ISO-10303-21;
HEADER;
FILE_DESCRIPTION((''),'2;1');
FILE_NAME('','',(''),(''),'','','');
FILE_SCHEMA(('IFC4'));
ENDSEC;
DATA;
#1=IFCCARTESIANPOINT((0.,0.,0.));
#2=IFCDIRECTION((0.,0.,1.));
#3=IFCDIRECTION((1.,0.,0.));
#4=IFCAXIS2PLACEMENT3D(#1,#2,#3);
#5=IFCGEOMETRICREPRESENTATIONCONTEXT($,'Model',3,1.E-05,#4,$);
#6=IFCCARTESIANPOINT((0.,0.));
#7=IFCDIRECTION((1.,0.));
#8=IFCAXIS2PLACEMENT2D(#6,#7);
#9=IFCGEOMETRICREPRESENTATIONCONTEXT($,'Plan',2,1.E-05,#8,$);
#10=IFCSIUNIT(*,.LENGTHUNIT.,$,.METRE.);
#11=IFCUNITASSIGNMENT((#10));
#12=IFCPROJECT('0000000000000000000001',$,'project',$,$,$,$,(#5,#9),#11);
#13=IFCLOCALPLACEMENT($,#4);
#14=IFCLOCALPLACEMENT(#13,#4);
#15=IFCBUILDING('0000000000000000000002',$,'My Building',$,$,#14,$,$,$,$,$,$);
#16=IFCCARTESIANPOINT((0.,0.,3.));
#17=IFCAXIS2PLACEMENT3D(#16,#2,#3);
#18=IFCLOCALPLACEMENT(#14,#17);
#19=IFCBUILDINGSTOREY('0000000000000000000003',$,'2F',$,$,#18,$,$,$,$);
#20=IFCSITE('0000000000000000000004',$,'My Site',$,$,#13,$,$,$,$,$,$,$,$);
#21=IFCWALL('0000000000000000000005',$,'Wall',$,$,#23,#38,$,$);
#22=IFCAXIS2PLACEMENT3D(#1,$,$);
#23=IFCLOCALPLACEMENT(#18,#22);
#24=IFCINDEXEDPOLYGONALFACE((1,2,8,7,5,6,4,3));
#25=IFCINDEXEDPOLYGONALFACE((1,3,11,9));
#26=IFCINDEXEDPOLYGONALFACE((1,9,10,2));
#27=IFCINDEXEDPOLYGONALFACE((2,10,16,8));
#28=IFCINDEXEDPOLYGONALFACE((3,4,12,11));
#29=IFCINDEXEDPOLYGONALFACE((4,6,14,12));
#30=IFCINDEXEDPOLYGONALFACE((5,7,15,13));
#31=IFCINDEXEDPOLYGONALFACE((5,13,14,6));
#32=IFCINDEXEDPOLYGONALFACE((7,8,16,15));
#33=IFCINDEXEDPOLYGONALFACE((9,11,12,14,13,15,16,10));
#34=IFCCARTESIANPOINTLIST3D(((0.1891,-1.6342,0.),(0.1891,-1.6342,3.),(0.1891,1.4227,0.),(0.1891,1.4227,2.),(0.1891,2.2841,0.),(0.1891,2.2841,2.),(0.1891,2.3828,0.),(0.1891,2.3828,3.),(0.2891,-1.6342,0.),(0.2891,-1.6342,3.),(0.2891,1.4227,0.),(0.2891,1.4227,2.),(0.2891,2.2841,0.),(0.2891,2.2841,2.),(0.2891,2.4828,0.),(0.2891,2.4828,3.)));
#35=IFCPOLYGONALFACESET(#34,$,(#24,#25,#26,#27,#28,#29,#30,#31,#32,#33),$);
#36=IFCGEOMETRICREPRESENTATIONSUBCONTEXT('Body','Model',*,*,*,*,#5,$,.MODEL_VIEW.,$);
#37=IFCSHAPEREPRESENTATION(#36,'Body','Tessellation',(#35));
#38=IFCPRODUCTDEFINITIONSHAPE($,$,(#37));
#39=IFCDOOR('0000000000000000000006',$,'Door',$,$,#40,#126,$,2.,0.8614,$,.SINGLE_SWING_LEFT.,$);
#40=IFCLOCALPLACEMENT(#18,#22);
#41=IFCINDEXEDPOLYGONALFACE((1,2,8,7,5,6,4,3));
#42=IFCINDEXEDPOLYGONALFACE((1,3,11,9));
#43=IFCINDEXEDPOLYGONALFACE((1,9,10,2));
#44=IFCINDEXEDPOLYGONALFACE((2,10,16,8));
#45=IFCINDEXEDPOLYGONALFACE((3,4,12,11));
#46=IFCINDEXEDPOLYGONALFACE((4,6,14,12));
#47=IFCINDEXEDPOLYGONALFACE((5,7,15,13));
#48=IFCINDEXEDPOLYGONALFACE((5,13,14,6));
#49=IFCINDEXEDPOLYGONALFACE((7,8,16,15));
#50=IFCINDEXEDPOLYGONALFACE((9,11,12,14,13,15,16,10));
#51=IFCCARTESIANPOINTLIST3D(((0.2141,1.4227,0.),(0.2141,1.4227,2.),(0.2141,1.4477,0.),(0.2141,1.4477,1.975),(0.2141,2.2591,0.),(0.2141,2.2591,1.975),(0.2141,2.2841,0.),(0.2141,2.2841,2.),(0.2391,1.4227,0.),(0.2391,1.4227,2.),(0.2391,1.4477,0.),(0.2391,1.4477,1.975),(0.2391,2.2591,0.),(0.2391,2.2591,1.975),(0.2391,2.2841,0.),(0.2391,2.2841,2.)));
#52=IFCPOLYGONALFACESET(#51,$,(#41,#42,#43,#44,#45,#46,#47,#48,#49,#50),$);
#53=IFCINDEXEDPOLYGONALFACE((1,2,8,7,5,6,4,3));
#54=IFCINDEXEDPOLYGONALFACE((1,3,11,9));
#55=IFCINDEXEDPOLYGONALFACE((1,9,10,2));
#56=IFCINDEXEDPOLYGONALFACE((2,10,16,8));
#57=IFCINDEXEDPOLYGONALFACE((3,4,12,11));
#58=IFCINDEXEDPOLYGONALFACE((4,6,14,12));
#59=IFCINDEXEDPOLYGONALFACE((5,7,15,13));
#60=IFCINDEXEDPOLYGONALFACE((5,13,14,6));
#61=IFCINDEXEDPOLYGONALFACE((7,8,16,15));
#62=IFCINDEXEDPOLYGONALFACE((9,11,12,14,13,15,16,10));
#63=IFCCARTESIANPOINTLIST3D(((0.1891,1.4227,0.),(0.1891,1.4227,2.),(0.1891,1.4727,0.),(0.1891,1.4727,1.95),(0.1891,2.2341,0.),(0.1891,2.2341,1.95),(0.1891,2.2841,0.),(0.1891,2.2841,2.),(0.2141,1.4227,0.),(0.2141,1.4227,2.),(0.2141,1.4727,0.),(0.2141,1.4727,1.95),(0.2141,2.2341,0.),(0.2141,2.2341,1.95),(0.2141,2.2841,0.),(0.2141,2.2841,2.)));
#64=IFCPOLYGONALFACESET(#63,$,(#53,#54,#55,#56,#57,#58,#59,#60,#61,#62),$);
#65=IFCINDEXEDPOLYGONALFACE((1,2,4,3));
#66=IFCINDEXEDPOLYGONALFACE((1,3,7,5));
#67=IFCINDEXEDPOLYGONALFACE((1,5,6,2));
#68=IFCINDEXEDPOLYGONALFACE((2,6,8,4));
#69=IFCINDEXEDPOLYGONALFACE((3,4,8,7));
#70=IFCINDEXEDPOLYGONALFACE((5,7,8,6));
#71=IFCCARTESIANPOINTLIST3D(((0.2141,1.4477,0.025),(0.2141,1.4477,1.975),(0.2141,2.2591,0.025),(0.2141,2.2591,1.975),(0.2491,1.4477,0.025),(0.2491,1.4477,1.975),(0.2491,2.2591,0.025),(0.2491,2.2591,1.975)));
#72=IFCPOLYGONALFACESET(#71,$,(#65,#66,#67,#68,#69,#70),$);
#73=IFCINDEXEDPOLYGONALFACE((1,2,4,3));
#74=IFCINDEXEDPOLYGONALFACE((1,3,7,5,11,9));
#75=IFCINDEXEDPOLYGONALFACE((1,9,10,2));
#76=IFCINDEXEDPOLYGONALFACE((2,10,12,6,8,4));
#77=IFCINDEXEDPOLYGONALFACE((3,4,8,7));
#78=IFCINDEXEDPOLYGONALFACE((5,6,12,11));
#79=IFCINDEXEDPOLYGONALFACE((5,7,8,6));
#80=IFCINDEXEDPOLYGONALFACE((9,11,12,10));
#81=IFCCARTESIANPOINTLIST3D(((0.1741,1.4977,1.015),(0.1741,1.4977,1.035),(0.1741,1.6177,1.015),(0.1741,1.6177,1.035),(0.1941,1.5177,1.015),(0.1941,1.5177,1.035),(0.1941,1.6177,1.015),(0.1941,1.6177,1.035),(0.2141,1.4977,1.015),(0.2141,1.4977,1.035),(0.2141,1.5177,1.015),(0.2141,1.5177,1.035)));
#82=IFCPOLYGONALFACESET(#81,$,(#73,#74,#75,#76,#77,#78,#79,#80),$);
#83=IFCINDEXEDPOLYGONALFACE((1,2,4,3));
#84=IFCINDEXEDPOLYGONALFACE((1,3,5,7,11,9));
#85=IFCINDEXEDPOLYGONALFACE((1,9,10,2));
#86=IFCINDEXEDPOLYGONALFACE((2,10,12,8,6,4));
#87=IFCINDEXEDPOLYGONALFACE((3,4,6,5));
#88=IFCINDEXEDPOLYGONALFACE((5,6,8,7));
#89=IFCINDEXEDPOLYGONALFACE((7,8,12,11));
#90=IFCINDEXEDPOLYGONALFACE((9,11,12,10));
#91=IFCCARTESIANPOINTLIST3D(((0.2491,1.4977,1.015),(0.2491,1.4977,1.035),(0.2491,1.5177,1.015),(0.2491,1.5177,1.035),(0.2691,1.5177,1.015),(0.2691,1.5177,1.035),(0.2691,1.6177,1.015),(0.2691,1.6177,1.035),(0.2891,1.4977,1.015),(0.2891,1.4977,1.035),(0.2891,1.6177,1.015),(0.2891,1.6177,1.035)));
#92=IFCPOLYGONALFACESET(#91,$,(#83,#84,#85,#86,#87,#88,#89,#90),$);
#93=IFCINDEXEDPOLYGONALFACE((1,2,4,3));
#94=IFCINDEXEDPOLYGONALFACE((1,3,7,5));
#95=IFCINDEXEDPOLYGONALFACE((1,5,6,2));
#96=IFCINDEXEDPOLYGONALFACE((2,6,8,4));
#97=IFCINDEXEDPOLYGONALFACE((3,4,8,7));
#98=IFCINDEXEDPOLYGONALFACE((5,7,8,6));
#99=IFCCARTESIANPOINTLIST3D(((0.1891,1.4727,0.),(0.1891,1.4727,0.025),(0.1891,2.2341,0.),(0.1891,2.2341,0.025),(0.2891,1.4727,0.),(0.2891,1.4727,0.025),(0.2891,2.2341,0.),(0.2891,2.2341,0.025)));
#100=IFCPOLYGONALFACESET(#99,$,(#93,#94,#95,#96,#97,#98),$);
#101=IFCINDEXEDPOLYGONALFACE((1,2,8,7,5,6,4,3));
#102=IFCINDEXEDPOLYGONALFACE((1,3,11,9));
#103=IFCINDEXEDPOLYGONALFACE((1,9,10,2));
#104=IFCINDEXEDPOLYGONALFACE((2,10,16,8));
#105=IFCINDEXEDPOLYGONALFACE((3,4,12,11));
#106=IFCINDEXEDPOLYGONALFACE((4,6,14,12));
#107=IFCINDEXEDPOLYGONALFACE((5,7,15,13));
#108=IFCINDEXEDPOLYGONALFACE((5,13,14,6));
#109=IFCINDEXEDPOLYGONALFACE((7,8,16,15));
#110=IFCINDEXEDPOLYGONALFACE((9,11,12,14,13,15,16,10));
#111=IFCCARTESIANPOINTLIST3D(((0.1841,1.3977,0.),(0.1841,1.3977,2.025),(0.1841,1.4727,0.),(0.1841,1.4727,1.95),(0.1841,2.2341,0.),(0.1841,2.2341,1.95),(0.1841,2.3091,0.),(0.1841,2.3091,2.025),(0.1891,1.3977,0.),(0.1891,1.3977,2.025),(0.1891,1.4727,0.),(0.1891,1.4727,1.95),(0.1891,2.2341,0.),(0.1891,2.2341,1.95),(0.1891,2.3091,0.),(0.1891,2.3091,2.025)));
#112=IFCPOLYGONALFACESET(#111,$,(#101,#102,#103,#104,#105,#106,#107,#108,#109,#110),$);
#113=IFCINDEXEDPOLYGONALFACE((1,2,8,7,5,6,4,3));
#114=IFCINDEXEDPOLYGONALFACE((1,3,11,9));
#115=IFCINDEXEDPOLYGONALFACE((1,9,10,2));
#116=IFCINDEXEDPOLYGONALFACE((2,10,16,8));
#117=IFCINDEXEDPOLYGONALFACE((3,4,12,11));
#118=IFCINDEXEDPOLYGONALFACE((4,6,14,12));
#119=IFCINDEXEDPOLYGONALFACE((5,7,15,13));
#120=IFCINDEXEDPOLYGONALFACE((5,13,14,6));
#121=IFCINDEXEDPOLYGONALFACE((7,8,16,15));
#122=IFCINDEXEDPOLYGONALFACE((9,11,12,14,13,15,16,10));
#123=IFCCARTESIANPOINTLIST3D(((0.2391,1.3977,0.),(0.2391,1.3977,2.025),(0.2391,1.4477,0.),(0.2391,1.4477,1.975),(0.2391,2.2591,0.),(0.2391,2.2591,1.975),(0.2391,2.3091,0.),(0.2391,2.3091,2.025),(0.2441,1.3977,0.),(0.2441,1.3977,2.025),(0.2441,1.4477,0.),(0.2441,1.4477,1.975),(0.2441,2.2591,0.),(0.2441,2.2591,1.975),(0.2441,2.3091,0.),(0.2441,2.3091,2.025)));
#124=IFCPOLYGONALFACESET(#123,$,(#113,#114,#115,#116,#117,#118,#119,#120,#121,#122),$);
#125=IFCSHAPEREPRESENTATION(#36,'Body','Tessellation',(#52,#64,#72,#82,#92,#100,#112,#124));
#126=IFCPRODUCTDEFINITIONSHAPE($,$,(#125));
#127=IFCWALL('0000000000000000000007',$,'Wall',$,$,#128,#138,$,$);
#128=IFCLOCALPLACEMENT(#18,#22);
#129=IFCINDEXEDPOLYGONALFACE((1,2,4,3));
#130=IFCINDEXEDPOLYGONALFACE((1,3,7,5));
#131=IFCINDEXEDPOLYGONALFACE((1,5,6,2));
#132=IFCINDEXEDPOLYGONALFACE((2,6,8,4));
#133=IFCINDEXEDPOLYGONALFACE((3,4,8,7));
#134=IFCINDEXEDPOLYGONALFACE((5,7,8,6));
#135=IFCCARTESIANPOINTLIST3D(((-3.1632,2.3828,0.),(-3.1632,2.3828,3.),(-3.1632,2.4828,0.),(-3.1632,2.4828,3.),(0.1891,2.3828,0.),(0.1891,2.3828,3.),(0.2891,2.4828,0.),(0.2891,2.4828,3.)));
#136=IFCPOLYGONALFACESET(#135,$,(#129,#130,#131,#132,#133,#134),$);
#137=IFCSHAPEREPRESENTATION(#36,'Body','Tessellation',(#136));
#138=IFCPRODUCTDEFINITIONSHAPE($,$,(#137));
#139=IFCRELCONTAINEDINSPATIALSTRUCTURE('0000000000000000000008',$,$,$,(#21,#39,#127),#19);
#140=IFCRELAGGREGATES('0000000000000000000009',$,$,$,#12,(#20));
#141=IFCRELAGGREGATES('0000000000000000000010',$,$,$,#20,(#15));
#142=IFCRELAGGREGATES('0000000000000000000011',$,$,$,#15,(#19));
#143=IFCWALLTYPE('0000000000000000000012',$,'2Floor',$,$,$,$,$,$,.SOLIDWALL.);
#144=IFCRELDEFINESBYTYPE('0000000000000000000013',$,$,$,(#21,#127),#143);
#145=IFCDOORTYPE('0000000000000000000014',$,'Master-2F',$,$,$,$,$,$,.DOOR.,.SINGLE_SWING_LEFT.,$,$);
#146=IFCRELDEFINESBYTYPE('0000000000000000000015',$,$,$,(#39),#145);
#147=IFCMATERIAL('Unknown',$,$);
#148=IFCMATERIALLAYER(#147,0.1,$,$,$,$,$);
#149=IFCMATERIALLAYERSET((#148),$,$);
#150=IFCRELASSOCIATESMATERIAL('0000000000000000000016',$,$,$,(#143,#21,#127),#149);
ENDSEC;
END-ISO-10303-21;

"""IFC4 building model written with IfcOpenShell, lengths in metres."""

from ifc_helpers import new_model, entity, si_unit, frame, origin_with_axes, origin_2d_with_axis, place, context, subcontext, project, spatial, line, indexed_curve, outline, extrude, shape, source, transform, mapped, material, layer, layer_set, layer_usage, type_object, type_shapes, element, fill, save


model = new_model("IFC4")

# Units and contexts
model_context = context("Model", 3, precision=1e-05, world=origin_with_axes())
plan_context = context("Plan", 2, precision=1e-05, world=origin_2d_with_axis())
body_context_1 = subcontext(model_context, "Body", "Model", "MODEL_VIEW")
body_context_2 = subcontext(plan_context, "Body", "Plan", "PLAN_VIEW")
ifc_project = project(units=[si_unit("LENGTHUNIT", "METRE")], contexts=[model_context, plan_context])

# Site, building, storey
site_placement = place(None, origin_with_axes())
site = spatial("IfcSite", under=ifc_project, at=site_placement, Name="My Site")
building_placement = place(site_placement, origin_with_axes())
building = spatial("IfcBuilding", under=site, at=building_placement, Name="My Building")
storey_placement = place(building_placement, frame((0.0, 0.0, 3.0), z_axis=(0.0, 0.0, 1.0), x_axis=(1.0, 0.0, 0.0)))
storey = spatial("IfcBuildingStorey", under=building, at=storey_placement, Name="2F")

# Shared definitions
ifc_material = material(Name="Unknown")

# Shared definitions
ifc_layer_1 = layer(ifc_material, 0.1)
ifc_layer_set_1 = layer_set([ifc_layer_1])
wall_type = type_object("IfcWallType", Name="2Floor", PredefinedType="SOLIDWALL", material=ifc_layer_set_1)

# Wall, opening, door
ifc_layer_usage_1 = layer_usage(ifc_layer_set_1, "AXIS2", "POSITIVE", 0.0)
wall_1_placement = place(storey_placement, frame((0.2891, -1.6342, 0.0), z_axis=(0.0, 0.0, 1.0), x_axis=(0.0, 1.0, 0.0)))
wall_1 = element("IfcWall", 1, at=wall_1_placement, inside=storey, type_object=wall_type, material=ifc_layer_usage_1, Name="Wall", context=body_context_1, shape_type="SweptSolid", body=[
    extrude(outline(indexed_curve([(0.0, 0.0), (0.0, 0.1), (4.0171, 0.1), (4.1171, 0.0)], segments=[line(1, 2, 3, 4, 1)])), origin_with_axes(), (0.0, 0.0, 1.0), 3.0),
])
shared_shape_1 = source(origin_with_axes(), body_context_1, "Body", "SweptSolid", [
    extrude(outline(indexed_curve([(0.0, 0.0), (0.8614, 0.0), (0.8614, 2.0), (0.0, 2.0)], segments=[line(1, 2, 3, 4, 1)])), frame((0.0, -0.6, 0.0), z_axis=(0.0, -1.0, 0.0), x_axis=(1.0, 0.0, 0.0)), (0.0, 0.0, -1.0), 1.2),
])
opening_1_placement = place(wall_1_placement, frame((3.9183, 0.1, 0.0), z_axis=(0.0, 0.0, 1.0), x_axis=(-1.0, 0.0, 0.0)))
opening_1 = element("IfcOpeningElement", 2, at=opening_1_placement, cuts=wall_1, PredefinedType="OPENING", context=body_context_1, shape_type="MappedRepresentation", body=[
    mapped(shared_shape_1, transform((0.0, 0.0, 0.0), x_axis=(1.0, 0.0, 0.0), y_axis=(0.0, 1.0, 0.0), z_axis=(0.0, 0.0, 1.0), scale=1.0)),
])
door_type_1 = type_object("IfcDoorType", Name="Master-2F", OperationType="SINGLE_SWING_LEFT", PredefinedType="DOOR")
shared_shape_2 = source(origin_with_axes(), body_context_1, "Body", "SweptSolid", [
    extrude(outline(indexed_curve([(0.0, 0.0), (0.0, 2.0), (0.8614, 2.0), (0.8614, 0.0), (0.8364, 0.0), (0.8364, 1.975), (0.025, 1.975), (0.025, 0.0)], segments=[line(1, 2, 3, 4, 5, 6, 7, 8, 1)])), frame((0.0, 0.025, 0.0), z_axis=(0.0, -1.0, 0.0), x_axis=(1.0, 0.0, 0.0)), (0.0, 0.0, -1.0), 0.025),
    extrude(outline(indexed_curve([(0.0, 0.0), (0.0, 2.0), (0.8614, 2.0), (0.8614, 0.0), (0.8114, 0.0), (0.8114, 1.95), (0.05, 1.95), (0.05, 0.0)], segments=[line(1, 2, 3, 4, 5, 6, 7, 8, 1)])), frame((0.0, 0.0, 0.0), z_axis=(0.0, -1.0, 0.0), x_axis=(1.0, 0.0, 0.0)), (0.0, 0.0, -1.0), 0.025),
    extrude(outline(indexed_curve([(0.0, 0.0), (0.8114, 0.0), (0.8114, 0.035), (0.0, 0.035)], segments=[line(1, 2, 3, 4, 1)])), frame((0.025, 0.025, 0.025), z_axis=(0.0, 0.0, 1.0), x_axis=(1.0, 0.0, 0.0)), (0.0, 0.0, 1.0), 1.95),
    extrude(outline(indexed_curve([(0.0, 0.0), (0.0, -0.04), (-0.12, -0.04), (-0.12, -0.02), (-0.02, -0.02), (-0.02, 0.0)], segments=[line(1, 2, 3, 4, 5, 6, 1)])), frame((0.7864, 0.025, 1.015), z_axis=(0.0, 0.0, 1.0), x_axis=(1.0, 0.0, 0.0)), (0.0, 0.0, 1.0), 0.02),
    extrude(outline(indexed_curve([(0.0, 0.0), (0.0, 0.04), (-0.12, 0.04), (-0.12, 0.02), (-0.02, 0.02), (-0.02, 0.0)], segments=[line(1, 2, 3, 4, 5, 6, 1)])), frame((0.7864, 0.06, 1.015), z_axis=(0.0, 0.0, 1.0), x_axis=(1.0, 0.0, 0.0)), (0.0, 0.0, 1.0), 0.02),
    extrude(outline(indexed_curve([(0.0, 0.0), (0.7614, 0.0), (0.7614, 0.1), (0.0, 0.1)], segments=[line(1, 2, 3, 4, 1)])), frame((0.05, 0.0, 0.0), z_axis=(0.0, 0.0, 1.0), x_axis=(1.0, 0.0, 0.0)), (0.0, 0.0, 1.0), 0.025),
    extrude(outline(indexed_curve([(0.0, 0.0), (0.0, 2.025), (0.9114, 2.025), (0.9114, 0.0), (0.8364, 0.0), (0.8364, 1.95), (0.075, 1.95), (0.075, 0.0)], segments=[line(1, 2, 3, 4, 5, 6, 7, 8, 1)])), frame((-0.025, -0.005, 0.0), z_axis=(0.0, -1.0, 0.0), x_axis=(1.0, 0.0, 0.0)), (0.0, 0.0, -1.0), 0.005),
    extrude(outline(indexed_curve([(0.0, 0.0), (0.0, 2.025), (0.9114, 2.025), (0.9114, 0.0), (0.8614, 0.0), (0.8614, 1.975), (0.05, 1.975), (0.05, 0.0)], segments=[line(1, 2, 3, 4, 5, 6, 7, 8, 1)])), frame((-0.025, 0.05, 0.0), z_axis=(0.0, -1.0, 0.0), x_axis=(1.0, 0.0, 0.0)), (0.0, 0.0, -1.0), 0.005),
])
shared_shape_3 = source(origin_with_axes(), body_context_2, "Body", "Curve2D", [
    entity("IfcIndexedPolyCurve", entity("IfcCartesianPointList2D", [[0.0, 0.0], [0.0, 0.05], [0.025, 0.05], [0.025, 0.025], [0.05, 0.025], [0.05, 0.0]]), [entity("IfcLineIndex", [1, 2, 3, 4, 5, 6, 1])]),
    entity("IfcIndexedPolyCurve", entity("IfcCartesianPointList2D", [[0.8614, 0.0], [0.8614, 0.05], [0.8364, 0.05], [0.8364, 0.025], [0.8114, 0.025], [0.8114, 0.0]]), [entity("IfcLineIndex", [1, 2, 3, 4, 5, 6, 1])]),
    entity("IfcTrimmedCurve", entity("IfcEllipse", entity("IfcAxis2Placement2D", entity("IfcCartesianPoint", [0.06, 0.05]), entity("IfcDirection", [1.0, 0.0])), 0.7764, 0.8114), [entity("IfcCartesianPoint", [0.8364, 0.05])], [entity("IfcCartesianPoint", [0.06, 0.8614])], True, "CARTESIAN"),
    entity("IfcIndexedPolyCurve", entity("IfcCartesianPointList2D", [[0.025, 0.05], [0.06, 0.05], [0.06, 0.8614], [0.025, 0.8614]]), [entity("IfcLineIndex", [1, 2, 3, 4, 1])]),
])
type_shapes(door_type_1, [shared_shape_2, shared_shape_3])
door_1_placement = place(opening_1_placement, frame((0.0, 0.0, 0.0), z_axis=(0.0, 0.0, 1.0), x_axis=(1.0, 0.0, 0.0)))
door_1 = element("IfcDoor", 3, at=door_1_placement, inside=storey, type_object=door_type_1, Name="Door", OperationType="SINGLE_SWING_LEFT", OverallHeight=2.0, OverallWidth=0.8614, shapes=[
    shape(body_context_1, "Body", "MappedRepresentation", [mapped(shared_shape_2, transform((0.0, 0.0, 0.0), x_axis=(1.0, 0.0, 0.0), y_axis=(0.0, 1.0, 0.0), z_axis=(0.0, 0.0, 1.0), scale=1.0))]),
    shape(body_context_2, "Body", "MappedRepresentation", [mapped(shared_shape_3, transform((0.0, 0.0, 0.0), x_axis=(1.0, 0.0, 0.0), y_axis=(0.0, 1.0, 0.0), z_axis=(0.0, 0.0, 1.0), scale=1.0))]),
])
fill(opening_1, door_1)

# Wall
ifc_layer_usage_2 = layer_usage(ifc_layer_set_1, "AXIS2", "POSITIVE", 0.0)
wall_2_placement = place(storey_placement, frame((0.2891, 2.4828, 0.0), z_axis=(0.0, 0.0, 1.0), x_axis=(-1.0, 0.0, 0.0)))
element("IfcWall", 4, at=wall_2_placement, inside=storey, type_object=wall_type, material=ifc_layer_usage_2, Name="Wall", context=body_context_1, shape_type="SweptSolid", body=[
    extrude(outline(indexed_curve([(0.0, 0.0), (0.1, 0.1), (3.4523, 0.1), (3.4523, 0.0)], segments=[line(1, 2, 3, 4, 1)])), origin_with_axes(), (0.0, 0.0, 1.0), 3.0),
])

save(model, "model.ifc")
